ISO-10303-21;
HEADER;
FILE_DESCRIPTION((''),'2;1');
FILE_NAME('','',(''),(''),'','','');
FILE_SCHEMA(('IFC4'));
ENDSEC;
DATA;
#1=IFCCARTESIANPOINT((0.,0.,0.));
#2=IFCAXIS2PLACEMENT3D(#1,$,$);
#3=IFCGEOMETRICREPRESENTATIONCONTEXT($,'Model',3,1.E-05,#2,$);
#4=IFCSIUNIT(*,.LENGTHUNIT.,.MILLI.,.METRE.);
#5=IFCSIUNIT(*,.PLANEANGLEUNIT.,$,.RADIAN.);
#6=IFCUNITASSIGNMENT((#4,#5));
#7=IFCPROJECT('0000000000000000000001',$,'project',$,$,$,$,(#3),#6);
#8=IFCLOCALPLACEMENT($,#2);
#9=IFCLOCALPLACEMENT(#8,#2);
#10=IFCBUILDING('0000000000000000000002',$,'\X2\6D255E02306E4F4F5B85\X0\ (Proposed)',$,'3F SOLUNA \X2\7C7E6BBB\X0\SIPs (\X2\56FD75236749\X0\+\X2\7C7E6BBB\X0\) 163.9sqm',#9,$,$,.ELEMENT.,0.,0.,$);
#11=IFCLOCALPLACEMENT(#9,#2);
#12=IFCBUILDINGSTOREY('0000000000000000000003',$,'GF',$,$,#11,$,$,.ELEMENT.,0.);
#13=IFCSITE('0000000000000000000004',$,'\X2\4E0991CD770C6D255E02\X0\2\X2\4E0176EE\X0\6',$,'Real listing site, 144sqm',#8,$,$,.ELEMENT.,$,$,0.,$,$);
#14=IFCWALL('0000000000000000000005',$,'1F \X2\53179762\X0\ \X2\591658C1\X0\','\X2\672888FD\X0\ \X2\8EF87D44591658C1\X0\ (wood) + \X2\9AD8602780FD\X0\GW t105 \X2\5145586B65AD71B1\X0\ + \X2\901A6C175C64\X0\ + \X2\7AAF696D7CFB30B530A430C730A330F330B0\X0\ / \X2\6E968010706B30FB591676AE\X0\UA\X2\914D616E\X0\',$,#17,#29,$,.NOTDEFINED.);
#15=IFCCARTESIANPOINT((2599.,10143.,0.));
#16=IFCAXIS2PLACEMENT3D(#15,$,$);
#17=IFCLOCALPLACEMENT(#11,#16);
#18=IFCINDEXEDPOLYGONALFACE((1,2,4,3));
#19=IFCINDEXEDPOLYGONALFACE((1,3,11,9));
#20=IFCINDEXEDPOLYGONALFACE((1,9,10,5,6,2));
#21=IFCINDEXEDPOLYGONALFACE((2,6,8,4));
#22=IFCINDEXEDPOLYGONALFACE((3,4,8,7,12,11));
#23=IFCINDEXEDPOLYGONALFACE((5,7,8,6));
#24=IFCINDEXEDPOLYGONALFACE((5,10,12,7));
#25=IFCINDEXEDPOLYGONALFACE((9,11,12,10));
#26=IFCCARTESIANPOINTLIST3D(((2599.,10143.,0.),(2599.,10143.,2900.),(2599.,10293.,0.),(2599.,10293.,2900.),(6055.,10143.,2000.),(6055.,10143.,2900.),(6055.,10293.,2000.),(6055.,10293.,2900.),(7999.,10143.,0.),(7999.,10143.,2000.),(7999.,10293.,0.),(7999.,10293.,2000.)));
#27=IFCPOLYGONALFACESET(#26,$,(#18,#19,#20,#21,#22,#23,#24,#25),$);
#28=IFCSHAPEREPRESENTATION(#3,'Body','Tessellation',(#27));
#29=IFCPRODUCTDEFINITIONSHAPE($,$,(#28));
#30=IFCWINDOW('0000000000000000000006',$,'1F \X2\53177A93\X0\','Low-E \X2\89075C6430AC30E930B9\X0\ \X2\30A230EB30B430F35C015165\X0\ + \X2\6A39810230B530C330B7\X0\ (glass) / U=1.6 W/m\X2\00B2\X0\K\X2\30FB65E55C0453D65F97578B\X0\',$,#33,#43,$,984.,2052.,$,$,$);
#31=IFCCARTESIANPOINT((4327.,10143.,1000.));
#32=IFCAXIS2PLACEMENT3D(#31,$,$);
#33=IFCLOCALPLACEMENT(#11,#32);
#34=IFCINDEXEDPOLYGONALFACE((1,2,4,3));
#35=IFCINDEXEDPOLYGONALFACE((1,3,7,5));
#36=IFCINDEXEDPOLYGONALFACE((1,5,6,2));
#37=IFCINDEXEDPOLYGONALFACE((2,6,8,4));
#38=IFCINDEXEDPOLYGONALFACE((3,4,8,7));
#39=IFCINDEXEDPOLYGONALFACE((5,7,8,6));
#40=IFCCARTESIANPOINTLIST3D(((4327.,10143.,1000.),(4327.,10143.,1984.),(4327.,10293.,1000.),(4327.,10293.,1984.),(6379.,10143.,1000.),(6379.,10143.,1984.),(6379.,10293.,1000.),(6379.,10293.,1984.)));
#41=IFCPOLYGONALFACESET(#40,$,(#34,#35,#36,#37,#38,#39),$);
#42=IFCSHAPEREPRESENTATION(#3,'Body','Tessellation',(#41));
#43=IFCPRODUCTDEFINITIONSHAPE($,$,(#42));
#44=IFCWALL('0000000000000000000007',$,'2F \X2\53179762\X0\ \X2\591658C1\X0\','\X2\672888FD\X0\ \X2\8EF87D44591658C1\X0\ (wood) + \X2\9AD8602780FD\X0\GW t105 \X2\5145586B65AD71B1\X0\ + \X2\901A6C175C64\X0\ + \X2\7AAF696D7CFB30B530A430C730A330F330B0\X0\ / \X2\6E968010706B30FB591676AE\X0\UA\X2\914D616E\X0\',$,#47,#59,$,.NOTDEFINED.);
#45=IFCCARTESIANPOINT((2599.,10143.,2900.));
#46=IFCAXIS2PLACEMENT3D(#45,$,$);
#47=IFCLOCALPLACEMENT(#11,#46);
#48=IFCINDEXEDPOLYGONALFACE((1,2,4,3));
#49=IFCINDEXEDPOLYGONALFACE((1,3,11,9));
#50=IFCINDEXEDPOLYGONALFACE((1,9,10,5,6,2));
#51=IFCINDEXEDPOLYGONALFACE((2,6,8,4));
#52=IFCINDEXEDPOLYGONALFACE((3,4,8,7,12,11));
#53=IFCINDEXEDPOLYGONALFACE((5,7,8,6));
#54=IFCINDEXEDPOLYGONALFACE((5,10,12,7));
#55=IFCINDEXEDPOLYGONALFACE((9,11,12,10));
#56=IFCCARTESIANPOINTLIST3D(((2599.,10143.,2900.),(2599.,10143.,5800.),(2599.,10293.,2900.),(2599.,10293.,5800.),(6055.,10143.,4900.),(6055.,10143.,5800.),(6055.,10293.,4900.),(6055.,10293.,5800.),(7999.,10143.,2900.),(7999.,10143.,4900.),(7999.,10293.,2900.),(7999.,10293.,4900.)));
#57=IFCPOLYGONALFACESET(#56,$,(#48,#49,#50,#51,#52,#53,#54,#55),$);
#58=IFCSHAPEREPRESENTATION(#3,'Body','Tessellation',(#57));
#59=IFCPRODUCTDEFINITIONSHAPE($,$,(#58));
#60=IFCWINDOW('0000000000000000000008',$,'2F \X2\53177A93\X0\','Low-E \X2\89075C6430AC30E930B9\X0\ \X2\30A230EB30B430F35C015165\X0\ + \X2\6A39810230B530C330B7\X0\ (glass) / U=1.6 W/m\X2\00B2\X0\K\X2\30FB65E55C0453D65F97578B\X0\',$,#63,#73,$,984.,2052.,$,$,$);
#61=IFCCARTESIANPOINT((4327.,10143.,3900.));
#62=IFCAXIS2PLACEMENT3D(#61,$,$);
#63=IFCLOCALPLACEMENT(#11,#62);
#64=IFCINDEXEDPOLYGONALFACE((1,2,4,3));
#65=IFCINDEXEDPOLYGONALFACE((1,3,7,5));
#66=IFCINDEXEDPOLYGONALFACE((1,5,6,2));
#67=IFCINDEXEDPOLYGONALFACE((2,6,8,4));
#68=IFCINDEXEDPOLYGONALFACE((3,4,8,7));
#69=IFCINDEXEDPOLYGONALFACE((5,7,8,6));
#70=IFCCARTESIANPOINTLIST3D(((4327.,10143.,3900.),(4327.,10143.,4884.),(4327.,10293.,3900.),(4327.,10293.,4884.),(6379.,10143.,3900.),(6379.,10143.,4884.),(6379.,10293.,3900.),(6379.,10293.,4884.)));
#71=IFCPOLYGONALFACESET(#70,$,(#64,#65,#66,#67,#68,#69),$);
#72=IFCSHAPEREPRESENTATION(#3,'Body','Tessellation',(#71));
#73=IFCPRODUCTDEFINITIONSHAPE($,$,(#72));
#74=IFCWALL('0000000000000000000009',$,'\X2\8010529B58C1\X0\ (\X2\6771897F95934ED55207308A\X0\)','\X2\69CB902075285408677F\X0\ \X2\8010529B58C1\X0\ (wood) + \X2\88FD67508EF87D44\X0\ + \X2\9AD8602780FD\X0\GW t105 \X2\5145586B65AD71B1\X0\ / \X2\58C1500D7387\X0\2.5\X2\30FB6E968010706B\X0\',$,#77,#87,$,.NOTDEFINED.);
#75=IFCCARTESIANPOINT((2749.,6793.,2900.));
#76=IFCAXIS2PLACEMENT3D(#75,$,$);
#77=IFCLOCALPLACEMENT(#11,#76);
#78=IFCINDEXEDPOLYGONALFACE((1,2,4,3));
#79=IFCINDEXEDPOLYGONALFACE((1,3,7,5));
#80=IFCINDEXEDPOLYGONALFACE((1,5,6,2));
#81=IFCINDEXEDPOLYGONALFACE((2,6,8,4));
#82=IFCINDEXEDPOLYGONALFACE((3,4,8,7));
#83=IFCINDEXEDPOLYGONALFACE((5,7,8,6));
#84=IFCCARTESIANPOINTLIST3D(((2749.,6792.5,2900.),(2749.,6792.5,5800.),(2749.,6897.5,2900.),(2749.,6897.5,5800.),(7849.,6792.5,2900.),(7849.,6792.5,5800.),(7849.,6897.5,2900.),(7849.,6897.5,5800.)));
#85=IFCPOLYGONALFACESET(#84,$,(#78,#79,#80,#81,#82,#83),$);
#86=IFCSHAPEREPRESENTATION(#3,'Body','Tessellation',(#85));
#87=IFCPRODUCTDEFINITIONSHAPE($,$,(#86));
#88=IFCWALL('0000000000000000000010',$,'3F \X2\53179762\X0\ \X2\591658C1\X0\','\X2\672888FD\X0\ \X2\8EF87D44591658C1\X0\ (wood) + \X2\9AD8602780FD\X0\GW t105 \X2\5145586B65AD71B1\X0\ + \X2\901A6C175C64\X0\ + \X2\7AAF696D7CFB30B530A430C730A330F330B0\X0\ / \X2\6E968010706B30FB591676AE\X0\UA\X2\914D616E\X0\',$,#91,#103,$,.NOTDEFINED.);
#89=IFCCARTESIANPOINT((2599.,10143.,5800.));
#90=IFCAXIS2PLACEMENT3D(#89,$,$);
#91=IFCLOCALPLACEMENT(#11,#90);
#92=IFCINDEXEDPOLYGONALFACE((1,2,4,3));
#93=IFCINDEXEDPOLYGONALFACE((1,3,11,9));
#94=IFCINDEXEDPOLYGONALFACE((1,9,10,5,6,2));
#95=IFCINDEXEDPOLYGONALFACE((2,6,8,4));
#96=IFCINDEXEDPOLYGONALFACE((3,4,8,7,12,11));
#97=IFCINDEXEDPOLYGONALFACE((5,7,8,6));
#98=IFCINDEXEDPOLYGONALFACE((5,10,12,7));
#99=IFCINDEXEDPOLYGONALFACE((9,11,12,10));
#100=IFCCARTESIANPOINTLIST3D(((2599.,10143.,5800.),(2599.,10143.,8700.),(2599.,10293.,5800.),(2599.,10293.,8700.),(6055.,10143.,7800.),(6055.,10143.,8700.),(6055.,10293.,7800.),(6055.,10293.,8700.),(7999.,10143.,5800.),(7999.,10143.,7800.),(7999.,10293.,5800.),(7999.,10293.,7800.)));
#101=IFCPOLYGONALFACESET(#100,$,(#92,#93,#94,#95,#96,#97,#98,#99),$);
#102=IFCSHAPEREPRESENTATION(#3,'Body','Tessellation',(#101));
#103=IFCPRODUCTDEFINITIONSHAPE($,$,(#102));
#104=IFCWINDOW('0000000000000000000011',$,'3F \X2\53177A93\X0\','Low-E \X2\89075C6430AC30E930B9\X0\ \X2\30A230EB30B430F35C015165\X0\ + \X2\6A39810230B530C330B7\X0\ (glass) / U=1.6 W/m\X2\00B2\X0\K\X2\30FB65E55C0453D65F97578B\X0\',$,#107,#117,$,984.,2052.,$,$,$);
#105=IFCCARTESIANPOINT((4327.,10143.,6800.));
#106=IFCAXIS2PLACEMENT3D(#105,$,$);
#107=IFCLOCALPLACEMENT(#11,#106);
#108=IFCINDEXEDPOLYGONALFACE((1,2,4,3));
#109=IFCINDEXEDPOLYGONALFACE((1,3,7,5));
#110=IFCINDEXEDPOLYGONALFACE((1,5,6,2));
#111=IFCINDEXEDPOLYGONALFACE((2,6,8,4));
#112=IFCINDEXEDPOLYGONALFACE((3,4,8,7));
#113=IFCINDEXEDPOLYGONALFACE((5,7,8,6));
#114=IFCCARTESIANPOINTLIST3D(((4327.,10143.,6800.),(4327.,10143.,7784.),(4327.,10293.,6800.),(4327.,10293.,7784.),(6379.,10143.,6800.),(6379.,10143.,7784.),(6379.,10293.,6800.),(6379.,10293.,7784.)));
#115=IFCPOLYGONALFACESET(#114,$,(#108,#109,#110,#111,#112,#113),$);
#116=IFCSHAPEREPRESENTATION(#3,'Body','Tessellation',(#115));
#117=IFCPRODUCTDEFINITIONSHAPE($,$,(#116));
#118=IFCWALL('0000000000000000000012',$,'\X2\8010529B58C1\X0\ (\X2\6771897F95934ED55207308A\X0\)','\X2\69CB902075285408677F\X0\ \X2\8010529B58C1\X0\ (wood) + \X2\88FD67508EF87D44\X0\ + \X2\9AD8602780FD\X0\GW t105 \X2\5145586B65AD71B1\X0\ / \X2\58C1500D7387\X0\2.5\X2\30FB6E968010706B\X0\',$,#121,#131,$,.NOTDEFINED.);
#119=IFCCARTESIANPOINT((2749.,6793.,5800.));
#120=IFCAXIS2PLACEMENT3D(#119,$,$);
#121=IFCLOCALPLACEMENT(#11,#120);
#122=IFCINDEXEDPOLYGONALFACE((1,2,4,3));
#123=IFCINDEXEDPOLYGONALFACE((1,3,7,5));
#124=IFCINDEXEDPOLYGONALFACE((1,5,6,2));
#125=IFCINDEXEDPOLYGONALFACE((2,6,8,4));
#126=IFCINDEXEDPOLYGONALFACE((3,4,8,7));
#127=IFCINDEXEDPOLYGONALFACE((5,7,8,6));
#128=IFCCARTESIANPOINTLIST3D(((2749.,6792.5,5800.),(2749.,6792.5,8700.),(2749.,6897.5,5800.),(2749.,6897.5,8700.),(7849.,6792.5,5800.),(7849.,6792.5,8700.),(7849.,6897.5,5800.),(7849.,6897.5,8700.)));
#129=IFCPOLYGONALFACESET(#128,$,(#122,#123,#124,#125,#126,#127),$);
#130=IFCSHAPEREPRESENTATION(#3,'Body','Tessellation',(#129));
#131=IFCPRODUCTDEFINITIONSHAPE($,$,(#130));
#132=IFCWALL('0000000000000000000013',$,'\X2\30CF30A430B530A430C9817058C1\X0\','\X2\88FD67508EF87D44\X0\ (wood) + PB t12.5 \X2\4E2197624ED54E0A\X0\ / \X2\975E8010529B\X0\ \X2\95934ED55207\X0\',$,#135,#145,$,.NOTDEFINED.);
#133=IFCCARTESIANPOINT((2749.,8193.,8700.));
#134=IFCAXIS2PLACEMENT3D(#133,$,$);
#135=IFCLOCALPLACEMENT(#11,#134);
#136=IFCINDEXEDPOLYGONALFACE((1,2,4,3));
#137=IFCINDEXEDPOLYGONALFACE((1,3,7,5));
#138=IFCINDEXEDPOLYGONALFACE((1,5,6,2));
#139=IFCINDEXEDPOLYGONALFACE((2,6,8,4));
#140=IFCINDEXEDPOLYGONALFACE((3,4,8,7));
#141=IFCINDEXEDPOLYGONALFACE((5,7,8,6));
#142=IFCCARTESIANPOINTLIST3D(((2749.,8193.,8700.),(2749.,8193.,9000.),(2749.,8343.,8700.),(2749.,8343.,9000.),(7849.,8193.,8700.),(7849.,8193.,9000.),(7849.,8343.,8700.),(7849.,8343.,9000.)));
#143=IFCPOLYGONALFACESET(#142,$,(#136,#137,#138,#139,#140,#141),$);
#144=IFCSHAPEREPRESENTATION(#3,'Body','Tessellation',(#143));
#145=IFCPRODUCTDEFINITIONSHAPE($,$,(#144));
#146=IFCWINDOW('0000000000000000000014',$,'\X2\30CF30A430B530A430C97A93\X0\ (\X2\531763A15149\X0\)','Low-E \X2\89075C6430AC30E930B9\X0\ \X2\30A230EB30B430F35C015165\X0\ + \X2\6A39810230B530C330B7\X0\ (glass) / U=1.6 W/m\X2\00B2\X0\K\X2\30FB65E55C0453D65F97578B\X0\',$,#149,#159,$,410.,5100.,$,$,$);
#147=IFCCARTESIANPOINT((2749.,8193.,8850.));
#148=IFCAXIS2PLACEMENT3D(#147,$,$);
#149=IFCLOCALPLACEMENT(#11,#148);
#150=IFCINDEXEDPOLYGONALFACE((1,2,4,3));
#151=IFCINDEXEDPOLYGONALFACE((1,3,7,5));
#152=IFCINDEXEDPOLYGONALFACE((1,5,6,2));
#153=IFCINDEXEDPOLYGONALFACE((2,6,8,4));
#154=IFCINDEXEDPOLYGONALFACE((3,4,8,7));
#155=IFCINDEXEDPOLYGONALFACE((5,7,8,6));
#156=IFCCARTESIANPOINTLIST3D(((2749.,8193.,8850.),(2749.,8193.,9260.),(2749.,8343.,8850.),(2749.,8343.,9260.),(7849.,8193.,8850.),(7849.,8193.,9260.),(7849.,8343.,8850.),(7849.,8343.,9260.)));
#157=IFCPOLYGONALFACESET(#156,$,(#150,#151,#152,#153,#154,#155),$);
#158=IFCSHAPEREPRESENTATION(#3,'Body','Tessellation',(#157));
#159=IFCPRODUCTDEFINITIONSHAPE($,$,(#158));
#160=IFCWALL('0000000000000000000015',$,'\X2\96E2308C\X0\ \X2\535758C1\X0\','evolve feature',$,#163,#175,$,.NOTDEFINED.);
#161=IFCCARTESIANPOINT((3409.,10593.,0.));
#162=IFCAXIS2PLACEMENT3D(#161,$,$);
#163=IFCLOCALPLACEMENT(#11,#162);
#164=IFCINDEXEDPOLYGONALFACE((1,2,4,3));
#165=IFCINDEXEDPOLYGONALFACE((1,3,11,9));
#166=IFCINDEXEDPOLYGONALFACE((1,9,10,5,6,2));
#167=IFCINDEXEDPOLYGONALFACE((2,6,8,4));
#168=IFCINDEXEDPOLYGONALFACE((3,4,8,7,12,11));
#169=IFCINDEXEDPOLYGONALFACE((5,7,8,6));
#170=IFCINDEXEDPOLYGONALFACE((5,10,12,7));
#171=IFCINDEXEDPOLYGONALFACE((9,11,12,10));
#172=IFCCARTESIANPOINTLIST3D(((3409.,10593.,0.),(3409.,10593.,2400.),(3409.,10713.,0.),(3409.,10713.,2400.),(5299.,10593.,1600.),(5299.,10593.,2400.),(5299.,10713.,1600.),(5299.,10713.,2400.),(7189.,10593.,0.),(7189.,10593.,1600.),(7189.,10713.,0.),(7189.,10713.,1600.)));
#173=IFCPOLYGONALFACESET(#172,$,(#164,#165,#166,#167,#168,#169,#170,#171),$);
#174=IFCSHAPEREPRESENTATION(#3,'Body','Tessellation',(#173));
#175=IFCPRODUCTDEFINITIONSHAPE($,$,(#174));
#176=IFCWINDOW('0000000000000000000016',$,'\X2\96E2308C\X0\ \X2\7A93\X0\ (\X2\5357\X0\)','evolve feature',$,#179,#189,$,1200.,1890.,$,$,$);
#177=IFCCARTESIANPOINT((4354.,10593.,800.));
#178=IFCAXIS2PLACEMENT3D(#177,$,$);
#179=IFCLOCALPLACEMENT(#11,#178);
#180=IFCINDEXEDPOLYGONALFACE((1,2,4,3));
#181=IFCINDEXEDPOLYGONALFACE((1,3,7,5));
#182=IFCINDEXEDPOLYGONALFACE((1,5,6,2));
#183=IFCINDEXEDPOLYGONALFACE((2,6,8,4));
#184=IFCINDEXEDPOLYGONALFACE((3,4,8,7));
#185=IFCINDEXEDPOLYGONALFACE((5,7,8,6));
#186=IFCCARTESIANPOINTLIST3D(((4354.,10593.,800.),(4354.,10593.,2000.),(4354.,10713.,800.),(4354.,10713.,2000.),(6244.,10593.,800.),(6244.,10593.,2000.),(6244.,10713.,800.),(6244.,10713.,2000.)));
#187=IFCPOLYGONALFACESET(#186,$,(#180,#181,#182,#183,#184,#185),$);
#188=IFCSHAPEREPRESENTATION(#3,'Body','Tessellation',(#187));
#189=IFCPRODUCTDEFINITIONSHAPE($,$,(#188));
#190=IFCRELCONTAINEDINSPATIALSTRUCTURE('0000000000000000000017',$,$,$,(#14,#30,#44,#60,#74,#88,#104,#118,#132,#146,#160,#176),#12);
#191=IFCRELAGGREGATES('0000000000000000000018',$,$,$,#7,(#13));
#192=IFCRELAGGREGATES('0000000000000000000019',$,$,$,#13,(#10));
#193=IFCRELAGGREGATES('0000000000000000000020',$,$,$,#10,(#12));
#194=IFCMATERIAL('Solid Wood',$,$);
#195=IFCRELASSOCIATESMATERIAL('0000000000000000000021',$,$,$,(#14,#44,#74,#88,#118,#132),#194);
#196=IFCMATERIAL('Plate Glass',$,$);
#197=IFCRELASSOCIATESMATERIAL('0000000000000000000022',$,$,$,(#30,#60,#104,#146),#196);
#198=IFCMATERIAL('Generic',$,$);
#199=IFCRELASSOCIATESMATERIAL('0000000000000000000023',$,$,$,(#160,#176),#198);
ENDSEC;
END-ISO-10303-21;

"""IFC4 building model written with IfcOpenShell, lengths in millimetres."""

from ifc_helpers import new_model, si_unit, frame, frame_2d, origin, place, context, project, spatial, rectangle, extrude, material, element, fill, save


model = new_model("IFC4")

# Units and contexts
model_context = context("Model", 3, precision=1e-05, world=origin())
ifc_project = project(units=[si_unit("LENGTHUNIT", "METRE", prefix="MILLI"), si_unit("PLANEANGLEUNIT", "RADIAN")], contexts=[model_context])

# Site, building, storey
site_placement = place(None, origin())
site = spatial("IfcSite", under=ifc_project, at=site_placement, Name="三重県津市2丁目6", ObjectType="Real listing site, 144sqm", CompositionType="ELEMENT", RefElevation=0.0)
building_placement = place(site_placement, origin())
building = spatial("IfcBuilding", under=site, at=building_placement, Name="津市の住宅 (Proposed)", ObjectType="3F SOLUNA 籾殻SIPs (国産杉+籾殻) 163.9sqm", CompositionType="ELEMENT", ElevationOfRefHeight=0.0, ElevationOfTerrain=0.0)
storey_placement = place(building_placement, origin())
storey = spatial("IfcBuildingStorey", under=building, at=storey_placement, Name="GF", CompositionType="ELEMENT", Elevation=0.0)

# Shared definitions
ifc_material_1 = material(Name="Generic")

# Wall, opening, window
ifc_material_2 = material(Name="Solid Wood")
wall_1_placement = place(storey_placement, frame((2599.0, 10143.0, 0.0)))
wall_1 = element("IfcWall", 1, at=wall_1_placement, inside=storey, material=ifc_material_2, Name="1F 北面 外壁", Description="木製 軸組外壁 (wood) + 高性能GW t105 充填断熱 + 通気層 + 窯業系サイディング / 準耐火・外皮UA配慮", PredefinedType="NOTDEFINED", context=model_context, shape_type="SweptSolid", body=[
    extrude(rectangle(XDim=5400.0, YDim=150.0, at=frame_2d((2700.0, 75.0))), frame((2599.0, 10143.0, 0.0)), (0.0, 0.0, 1.0), 2900.0),
])
opening_1_placement = place(storey_placement, frame((4327.0, 10143.0, 1000.0)))
opening_1 = element("IfcOpeningElement", 2, at=opening_1_placement, cuts=wall_1, PredefinedType="NOTDEFINED", context=model_context, shape_type="SweptSolid", body=[
    extrude(rectangle(XDim=2052.0, YDim=150.0, at=frame_2d((1026.0, 75.0))), frame((4327.0, 10143.0, 1000.0)), (0.0, 0.0, 1.0), 984.0),
])
ifc_material_3 = material(Name="Plate Glass")
window_1_placement = place(storey_placement, frame((4327.0, 10143.0, 1000.0)))
window_1 = element("IfcWindow", 3, at=window_1_placement, inside=storey, material=ifc_material_3, Name="1F 北窓", Description="Low-E 複層ガラス アルゴン封入 + 樹脂サッシ (glass) / U=1.6 W/m²K・日射取得型", OverallHeight=984.0, OverallWidth=2052.0, context=model_context, shape_type="SweptSolid", body=[
    extrude(rectangle(XDim=2052.0, YDim=150.0, at=frame_2d((1026.0, 75.0))), frame((4327.0, 10143.0, 1000.0)), (0.0, 0.0, 1.0), 984.0),
])
fill(opening_1, window_1)

# Wall, opening, window
wall_2_placement = place(storey_placement, frame((2599.0, 10143.0, 2900.0)))
wall_2 = element("IfcWall", 4, at=wall_2_placement, inside=storey, material=ifc_material_2, Name="2F 北面 外壁", Description="木製 軸組外壁 (wood) + 高性能GW t105 充填断熱 + 通気層 + 窯業系サイディング / 準耐火・外皮UA配慮", PredefinedType="NOTDEFINED", context=model_context, shape_type="SweptSolid", body=[
    extrude(rectangle(XDim=5400.0, YDim=150.0, at=frame_2d((2700.0, 75.0))), frame((2599.0, 10143.0, 2900.0)), (0.0, 0.0, 1.0), 2900.0),
])
opening_2_placement = place(storey_placement, frame((4327.0, 10143.0, 3900.0)))
opening_2 = element("IfcOpeningElement", 5, at=opening_2_placement, cuts=wall_2, PredefinedType="NOTDEFINED", context=model_context, shape_type="SweptSolid", body=[
    extrude(rectangle(XDim=2052.0, YDim=150.0, at=frame_2d((1026.0, 75.0))), frame((4327.0, 10143.0, 3900.0)), (0.0, 0.0, 1.0), 984.0),
])
window_2_placement = place(storey_placement, frame((4327.0, 10143.0, 3900.0)))
window_2 = element("IfcWindow", 6, at=window_2_placement, inside=storey, material=ifc_material_3, Name="2F 北窓", Description="Low-E 複層ガラス アルゴン封入 + 樹脂サッシ (glass) / U=1.6 W/m²K・日射取得型", OverallHeight=984.0, OverallWidth=2052.0, context=model_context, shape_type="SweptSolid", body=[
    extrude(rectangle(XDim=2052.0, YDim=150.0, at=frame_2d((1026.0, 75.0))), frame((4327.0, 10143.0, 3900.0)), (0.0, 0.0, 1.0), 984.0),
])
fill(opening_2, window_2)

# Wall
wall_3_placement = place(storey_placement, frame((2749.0, 6793.0, 2900.0)))
element("IfcWall", 7, at=wall_3_placement, inside=storey, material=ifc_material_2, Name="耐力壁 (東西間仕切り)", Description="構造用合板 耐力壁 (wood) + 製材軸組 + 高性能GW t105 充填断熱 / 壁倍率2.5・準耐火", PredefinedType="NOTDEFINED", context=model_context, shape_type="SweptSolid", body=[
    extrude(rectangle(XDim=5100.0, YDim=105.0, at=frame_2d((2550.0, 52.0))), frame((2749.0, 6793.0, 2900.0)), (0.0, 0.0, 1.0), 2900.0),
])

# Wall, opening, window
wall_4_placement = place(storey_placement, frame((2599.0, 10143.0, 5800.0)))
wall_4 = element("IfcWall", 8, at=wall_4_placement, inside=storey, material=ifc_material_2, Name="3F 北面 外壁", Description="木製 軸組外壁 (wood) + 高性能GW t105 充填断熱 + 通気層 + 窯業系サイディング / 準耐火・外皮UA配慮", PredefinedType="NOTDEFINED", context=model_context, shape_type="SweptSolid", body=[
    extrude(rectangle(XDim=5400.0, YDim=150.0, at=frame_2d((2700.0, 75.0))), frame((2599.0, 10143.0, 5800.0)), (0.0, 0.0, 1.0), 2900.0),
])
opening_3_placement = place(storey_placement, frame((4327.0, 10143.0, 6800.0)))
opening_3 = element("IfcOpeningElement", 9, at=opening_3_placement, cuts=wall_4, PredefinedType="NOTDEFINED", context=model_context, shape_type="SweptSolid", body=[
    extrude(rectangle(XDim=2052.0, YDim=150.0, at=frame_2d((1026.0, 75.0))), frame((4327.0, 10143.0, 6800.0)), (0.0, 0.0, 1.0), 984.0),
])
window_3_placement = place(storey_placement, frame((4327.0, 10143.0, 6800.0)))
window_3 = element("IfcWindow", 10, at=window_3_placement, inside=storey, material=ifc_material_3, Name="3F 北窓", Description="Low-E 複層ガラス アルゴン封入 + 樹脂サッシ (glass) / U=1.6 W/m²K・日射取得型", OverallHeight=984.0, OverallWidth=2052.0, context=model_context, shape_type="SweptSolid", body=[
    extrude(rectangle(XDim=2052.0, YDim=150.0, at=frame_2d((1026.0, 75.0))), frame((4327.0, 10143.0, 6800.0)), (0.0, 0.0, 1.0), 984.0),
])
fill(opening_3, window_3)

# Wall
wall_5_placement = place(storey_placement, frame((2749.0, 6793.0, 5800.0)))
element("IfcWall", 11, at=wall_5_placement, inside=storey, material=ifc_material_2, Name="耐力壁 (東西間仕切り)", Description="構造用合板 耐力壁 (wood) + 製材軸組 + 高性能GW t105 充填断熱 / 壁倍率2.5・準耐火", PredefinedType="NOTDEFINED", context=model_context, shape_type="SweptSolid", body=[
    extrude(rectangle(XDim=5100.0, YDim=105.0, at=frame_2d((2550.0, 52.0))), frame((2749.0, 6793.0, 5800.0)), (0.0, 0.0, 1.0), 2900.0),
])

# Walls, openings, windows
wall_6_placement = place(storey_placement, frame((2749.0, 8193.0, 8700.0)))
wall_6 = element("IfcWall", 12, at=wall_6_placement, inside=storey, material=ifc_material_2, Name="ハイサイド腰壁", Description="製材軸組 (wood) + PB t12.5 両面仕上 / 非耐力 間仕切", PredefinedType="NOTDEFINED", context=model_context, shape_type="SweptSolid", body=[
    extrude(rectangle(XDim=5100.0, YDim=150.0, at=frame_2d((2550.0, 75.0))), frame((2749.0, 8193.0, 8700.0)), (0.0, 0.0, 1.0), 700.0),
])
opening_4_placement = place(storey_placement, frame((2749.0, 8193.0, 8850.0)))
opening_4 = element("IfcOpeningElement", 13, at=opening_4_placement, cuts=wall_6, PredefinedType="NOTDEFINED", context=model_context, shape_type="SweptSolid", body=[
    extrude(rectangle(XDim=5100.0, YDim=150.0, at=frame_2d((2550.0, 75.0))), frame((2749.0, 8193.0, 8850.0)), (0.0, 0.0, 1.0), 410.0),
])
window_4_placement = place(storey_placement, frame((2749.0, 8193.0, 8850.0)))
window_4 = element("IfcWindow", 14, at=window_4_placement, inside=storey, material=ifc_material_3, Name="ハイサイド窓 (北採光)", Description="Low-E 複層ガラス アルゴン封入 + 樹脂サッシ (glass) / U=1.6 W/m²K・日射取得型", OverallHeight=410.0, OverallWidth=5100.0, context=model_context, shape_type="SweptSolid", body=[
    extrude(rectangle(XDim=5100.0, YDim=150.0, at=frame_2d((2550.0, 75.0))), frame((2749.0, 8193.0, 8850.0)), (0.0, 0.0, 1.0), 410.0),
])
fill(opening_4, window_4)
wall_7_placement = place(storey_placement, frame((3409.0, 10593.0, 0.0)))
wall_7 = element("IfcWall", 15, at=wall_7_placement, inside=storey, material=ifc_material_1, Name="離れ 南壁", Description="evolve feature", PredefinedType="NOTDEFINED", context=model_context, shape_type="SweptSolid", body=[
    extrude(rectangle(XDim=3780.0, YDim=120.0, at=frame_2d((1890.0, 60.0))), frame((3409.0, 10593.0, 0.0)), (0.0, 0.0, 1.0), 2400.0),
])
opening_5_placement = place(storey_placement, frame((4354.0, 10593.0, 800.0)))
opening_5 = element("IfcOpeningElement", 16, at=opening_5_placement, cuts=wall_7, PredefinedType="NOTDEFINED", context=model_context, shape_type="SweptSolid", body=[
    extrude(rectangle(XDim=1890.0, YDim=120.0, at=frame_2d((945.0, 60.0))), frame((4354.0, 10593.0, 800.0)), (0.0, 0.0, 1.0), 1200.0),
])
window_5_placement = place(storey_placement, frame((4354.0, 10593.0, 800.0)))
window_5 = element("IfcWindow", 17, at=window_5_placement, inside=storey, material=ifc_material_1, Name="離れ 窓 (南)", Description="evolve feature", OverallHeight=1200.0, OverallWidth=1890.0, context=model_context, shape_type="SweptSolid", body=[
    extrude(rectangle(XDim=1890.0, YDim=120.0, at=frame_2d((945.0, 60.0))), frame((4354.0, 10593.0, 800.0)), (0.0, 0.0, 1.0), 1200.0),
])
fill(opening_5, window_5)

save(model, "model.ifc")
